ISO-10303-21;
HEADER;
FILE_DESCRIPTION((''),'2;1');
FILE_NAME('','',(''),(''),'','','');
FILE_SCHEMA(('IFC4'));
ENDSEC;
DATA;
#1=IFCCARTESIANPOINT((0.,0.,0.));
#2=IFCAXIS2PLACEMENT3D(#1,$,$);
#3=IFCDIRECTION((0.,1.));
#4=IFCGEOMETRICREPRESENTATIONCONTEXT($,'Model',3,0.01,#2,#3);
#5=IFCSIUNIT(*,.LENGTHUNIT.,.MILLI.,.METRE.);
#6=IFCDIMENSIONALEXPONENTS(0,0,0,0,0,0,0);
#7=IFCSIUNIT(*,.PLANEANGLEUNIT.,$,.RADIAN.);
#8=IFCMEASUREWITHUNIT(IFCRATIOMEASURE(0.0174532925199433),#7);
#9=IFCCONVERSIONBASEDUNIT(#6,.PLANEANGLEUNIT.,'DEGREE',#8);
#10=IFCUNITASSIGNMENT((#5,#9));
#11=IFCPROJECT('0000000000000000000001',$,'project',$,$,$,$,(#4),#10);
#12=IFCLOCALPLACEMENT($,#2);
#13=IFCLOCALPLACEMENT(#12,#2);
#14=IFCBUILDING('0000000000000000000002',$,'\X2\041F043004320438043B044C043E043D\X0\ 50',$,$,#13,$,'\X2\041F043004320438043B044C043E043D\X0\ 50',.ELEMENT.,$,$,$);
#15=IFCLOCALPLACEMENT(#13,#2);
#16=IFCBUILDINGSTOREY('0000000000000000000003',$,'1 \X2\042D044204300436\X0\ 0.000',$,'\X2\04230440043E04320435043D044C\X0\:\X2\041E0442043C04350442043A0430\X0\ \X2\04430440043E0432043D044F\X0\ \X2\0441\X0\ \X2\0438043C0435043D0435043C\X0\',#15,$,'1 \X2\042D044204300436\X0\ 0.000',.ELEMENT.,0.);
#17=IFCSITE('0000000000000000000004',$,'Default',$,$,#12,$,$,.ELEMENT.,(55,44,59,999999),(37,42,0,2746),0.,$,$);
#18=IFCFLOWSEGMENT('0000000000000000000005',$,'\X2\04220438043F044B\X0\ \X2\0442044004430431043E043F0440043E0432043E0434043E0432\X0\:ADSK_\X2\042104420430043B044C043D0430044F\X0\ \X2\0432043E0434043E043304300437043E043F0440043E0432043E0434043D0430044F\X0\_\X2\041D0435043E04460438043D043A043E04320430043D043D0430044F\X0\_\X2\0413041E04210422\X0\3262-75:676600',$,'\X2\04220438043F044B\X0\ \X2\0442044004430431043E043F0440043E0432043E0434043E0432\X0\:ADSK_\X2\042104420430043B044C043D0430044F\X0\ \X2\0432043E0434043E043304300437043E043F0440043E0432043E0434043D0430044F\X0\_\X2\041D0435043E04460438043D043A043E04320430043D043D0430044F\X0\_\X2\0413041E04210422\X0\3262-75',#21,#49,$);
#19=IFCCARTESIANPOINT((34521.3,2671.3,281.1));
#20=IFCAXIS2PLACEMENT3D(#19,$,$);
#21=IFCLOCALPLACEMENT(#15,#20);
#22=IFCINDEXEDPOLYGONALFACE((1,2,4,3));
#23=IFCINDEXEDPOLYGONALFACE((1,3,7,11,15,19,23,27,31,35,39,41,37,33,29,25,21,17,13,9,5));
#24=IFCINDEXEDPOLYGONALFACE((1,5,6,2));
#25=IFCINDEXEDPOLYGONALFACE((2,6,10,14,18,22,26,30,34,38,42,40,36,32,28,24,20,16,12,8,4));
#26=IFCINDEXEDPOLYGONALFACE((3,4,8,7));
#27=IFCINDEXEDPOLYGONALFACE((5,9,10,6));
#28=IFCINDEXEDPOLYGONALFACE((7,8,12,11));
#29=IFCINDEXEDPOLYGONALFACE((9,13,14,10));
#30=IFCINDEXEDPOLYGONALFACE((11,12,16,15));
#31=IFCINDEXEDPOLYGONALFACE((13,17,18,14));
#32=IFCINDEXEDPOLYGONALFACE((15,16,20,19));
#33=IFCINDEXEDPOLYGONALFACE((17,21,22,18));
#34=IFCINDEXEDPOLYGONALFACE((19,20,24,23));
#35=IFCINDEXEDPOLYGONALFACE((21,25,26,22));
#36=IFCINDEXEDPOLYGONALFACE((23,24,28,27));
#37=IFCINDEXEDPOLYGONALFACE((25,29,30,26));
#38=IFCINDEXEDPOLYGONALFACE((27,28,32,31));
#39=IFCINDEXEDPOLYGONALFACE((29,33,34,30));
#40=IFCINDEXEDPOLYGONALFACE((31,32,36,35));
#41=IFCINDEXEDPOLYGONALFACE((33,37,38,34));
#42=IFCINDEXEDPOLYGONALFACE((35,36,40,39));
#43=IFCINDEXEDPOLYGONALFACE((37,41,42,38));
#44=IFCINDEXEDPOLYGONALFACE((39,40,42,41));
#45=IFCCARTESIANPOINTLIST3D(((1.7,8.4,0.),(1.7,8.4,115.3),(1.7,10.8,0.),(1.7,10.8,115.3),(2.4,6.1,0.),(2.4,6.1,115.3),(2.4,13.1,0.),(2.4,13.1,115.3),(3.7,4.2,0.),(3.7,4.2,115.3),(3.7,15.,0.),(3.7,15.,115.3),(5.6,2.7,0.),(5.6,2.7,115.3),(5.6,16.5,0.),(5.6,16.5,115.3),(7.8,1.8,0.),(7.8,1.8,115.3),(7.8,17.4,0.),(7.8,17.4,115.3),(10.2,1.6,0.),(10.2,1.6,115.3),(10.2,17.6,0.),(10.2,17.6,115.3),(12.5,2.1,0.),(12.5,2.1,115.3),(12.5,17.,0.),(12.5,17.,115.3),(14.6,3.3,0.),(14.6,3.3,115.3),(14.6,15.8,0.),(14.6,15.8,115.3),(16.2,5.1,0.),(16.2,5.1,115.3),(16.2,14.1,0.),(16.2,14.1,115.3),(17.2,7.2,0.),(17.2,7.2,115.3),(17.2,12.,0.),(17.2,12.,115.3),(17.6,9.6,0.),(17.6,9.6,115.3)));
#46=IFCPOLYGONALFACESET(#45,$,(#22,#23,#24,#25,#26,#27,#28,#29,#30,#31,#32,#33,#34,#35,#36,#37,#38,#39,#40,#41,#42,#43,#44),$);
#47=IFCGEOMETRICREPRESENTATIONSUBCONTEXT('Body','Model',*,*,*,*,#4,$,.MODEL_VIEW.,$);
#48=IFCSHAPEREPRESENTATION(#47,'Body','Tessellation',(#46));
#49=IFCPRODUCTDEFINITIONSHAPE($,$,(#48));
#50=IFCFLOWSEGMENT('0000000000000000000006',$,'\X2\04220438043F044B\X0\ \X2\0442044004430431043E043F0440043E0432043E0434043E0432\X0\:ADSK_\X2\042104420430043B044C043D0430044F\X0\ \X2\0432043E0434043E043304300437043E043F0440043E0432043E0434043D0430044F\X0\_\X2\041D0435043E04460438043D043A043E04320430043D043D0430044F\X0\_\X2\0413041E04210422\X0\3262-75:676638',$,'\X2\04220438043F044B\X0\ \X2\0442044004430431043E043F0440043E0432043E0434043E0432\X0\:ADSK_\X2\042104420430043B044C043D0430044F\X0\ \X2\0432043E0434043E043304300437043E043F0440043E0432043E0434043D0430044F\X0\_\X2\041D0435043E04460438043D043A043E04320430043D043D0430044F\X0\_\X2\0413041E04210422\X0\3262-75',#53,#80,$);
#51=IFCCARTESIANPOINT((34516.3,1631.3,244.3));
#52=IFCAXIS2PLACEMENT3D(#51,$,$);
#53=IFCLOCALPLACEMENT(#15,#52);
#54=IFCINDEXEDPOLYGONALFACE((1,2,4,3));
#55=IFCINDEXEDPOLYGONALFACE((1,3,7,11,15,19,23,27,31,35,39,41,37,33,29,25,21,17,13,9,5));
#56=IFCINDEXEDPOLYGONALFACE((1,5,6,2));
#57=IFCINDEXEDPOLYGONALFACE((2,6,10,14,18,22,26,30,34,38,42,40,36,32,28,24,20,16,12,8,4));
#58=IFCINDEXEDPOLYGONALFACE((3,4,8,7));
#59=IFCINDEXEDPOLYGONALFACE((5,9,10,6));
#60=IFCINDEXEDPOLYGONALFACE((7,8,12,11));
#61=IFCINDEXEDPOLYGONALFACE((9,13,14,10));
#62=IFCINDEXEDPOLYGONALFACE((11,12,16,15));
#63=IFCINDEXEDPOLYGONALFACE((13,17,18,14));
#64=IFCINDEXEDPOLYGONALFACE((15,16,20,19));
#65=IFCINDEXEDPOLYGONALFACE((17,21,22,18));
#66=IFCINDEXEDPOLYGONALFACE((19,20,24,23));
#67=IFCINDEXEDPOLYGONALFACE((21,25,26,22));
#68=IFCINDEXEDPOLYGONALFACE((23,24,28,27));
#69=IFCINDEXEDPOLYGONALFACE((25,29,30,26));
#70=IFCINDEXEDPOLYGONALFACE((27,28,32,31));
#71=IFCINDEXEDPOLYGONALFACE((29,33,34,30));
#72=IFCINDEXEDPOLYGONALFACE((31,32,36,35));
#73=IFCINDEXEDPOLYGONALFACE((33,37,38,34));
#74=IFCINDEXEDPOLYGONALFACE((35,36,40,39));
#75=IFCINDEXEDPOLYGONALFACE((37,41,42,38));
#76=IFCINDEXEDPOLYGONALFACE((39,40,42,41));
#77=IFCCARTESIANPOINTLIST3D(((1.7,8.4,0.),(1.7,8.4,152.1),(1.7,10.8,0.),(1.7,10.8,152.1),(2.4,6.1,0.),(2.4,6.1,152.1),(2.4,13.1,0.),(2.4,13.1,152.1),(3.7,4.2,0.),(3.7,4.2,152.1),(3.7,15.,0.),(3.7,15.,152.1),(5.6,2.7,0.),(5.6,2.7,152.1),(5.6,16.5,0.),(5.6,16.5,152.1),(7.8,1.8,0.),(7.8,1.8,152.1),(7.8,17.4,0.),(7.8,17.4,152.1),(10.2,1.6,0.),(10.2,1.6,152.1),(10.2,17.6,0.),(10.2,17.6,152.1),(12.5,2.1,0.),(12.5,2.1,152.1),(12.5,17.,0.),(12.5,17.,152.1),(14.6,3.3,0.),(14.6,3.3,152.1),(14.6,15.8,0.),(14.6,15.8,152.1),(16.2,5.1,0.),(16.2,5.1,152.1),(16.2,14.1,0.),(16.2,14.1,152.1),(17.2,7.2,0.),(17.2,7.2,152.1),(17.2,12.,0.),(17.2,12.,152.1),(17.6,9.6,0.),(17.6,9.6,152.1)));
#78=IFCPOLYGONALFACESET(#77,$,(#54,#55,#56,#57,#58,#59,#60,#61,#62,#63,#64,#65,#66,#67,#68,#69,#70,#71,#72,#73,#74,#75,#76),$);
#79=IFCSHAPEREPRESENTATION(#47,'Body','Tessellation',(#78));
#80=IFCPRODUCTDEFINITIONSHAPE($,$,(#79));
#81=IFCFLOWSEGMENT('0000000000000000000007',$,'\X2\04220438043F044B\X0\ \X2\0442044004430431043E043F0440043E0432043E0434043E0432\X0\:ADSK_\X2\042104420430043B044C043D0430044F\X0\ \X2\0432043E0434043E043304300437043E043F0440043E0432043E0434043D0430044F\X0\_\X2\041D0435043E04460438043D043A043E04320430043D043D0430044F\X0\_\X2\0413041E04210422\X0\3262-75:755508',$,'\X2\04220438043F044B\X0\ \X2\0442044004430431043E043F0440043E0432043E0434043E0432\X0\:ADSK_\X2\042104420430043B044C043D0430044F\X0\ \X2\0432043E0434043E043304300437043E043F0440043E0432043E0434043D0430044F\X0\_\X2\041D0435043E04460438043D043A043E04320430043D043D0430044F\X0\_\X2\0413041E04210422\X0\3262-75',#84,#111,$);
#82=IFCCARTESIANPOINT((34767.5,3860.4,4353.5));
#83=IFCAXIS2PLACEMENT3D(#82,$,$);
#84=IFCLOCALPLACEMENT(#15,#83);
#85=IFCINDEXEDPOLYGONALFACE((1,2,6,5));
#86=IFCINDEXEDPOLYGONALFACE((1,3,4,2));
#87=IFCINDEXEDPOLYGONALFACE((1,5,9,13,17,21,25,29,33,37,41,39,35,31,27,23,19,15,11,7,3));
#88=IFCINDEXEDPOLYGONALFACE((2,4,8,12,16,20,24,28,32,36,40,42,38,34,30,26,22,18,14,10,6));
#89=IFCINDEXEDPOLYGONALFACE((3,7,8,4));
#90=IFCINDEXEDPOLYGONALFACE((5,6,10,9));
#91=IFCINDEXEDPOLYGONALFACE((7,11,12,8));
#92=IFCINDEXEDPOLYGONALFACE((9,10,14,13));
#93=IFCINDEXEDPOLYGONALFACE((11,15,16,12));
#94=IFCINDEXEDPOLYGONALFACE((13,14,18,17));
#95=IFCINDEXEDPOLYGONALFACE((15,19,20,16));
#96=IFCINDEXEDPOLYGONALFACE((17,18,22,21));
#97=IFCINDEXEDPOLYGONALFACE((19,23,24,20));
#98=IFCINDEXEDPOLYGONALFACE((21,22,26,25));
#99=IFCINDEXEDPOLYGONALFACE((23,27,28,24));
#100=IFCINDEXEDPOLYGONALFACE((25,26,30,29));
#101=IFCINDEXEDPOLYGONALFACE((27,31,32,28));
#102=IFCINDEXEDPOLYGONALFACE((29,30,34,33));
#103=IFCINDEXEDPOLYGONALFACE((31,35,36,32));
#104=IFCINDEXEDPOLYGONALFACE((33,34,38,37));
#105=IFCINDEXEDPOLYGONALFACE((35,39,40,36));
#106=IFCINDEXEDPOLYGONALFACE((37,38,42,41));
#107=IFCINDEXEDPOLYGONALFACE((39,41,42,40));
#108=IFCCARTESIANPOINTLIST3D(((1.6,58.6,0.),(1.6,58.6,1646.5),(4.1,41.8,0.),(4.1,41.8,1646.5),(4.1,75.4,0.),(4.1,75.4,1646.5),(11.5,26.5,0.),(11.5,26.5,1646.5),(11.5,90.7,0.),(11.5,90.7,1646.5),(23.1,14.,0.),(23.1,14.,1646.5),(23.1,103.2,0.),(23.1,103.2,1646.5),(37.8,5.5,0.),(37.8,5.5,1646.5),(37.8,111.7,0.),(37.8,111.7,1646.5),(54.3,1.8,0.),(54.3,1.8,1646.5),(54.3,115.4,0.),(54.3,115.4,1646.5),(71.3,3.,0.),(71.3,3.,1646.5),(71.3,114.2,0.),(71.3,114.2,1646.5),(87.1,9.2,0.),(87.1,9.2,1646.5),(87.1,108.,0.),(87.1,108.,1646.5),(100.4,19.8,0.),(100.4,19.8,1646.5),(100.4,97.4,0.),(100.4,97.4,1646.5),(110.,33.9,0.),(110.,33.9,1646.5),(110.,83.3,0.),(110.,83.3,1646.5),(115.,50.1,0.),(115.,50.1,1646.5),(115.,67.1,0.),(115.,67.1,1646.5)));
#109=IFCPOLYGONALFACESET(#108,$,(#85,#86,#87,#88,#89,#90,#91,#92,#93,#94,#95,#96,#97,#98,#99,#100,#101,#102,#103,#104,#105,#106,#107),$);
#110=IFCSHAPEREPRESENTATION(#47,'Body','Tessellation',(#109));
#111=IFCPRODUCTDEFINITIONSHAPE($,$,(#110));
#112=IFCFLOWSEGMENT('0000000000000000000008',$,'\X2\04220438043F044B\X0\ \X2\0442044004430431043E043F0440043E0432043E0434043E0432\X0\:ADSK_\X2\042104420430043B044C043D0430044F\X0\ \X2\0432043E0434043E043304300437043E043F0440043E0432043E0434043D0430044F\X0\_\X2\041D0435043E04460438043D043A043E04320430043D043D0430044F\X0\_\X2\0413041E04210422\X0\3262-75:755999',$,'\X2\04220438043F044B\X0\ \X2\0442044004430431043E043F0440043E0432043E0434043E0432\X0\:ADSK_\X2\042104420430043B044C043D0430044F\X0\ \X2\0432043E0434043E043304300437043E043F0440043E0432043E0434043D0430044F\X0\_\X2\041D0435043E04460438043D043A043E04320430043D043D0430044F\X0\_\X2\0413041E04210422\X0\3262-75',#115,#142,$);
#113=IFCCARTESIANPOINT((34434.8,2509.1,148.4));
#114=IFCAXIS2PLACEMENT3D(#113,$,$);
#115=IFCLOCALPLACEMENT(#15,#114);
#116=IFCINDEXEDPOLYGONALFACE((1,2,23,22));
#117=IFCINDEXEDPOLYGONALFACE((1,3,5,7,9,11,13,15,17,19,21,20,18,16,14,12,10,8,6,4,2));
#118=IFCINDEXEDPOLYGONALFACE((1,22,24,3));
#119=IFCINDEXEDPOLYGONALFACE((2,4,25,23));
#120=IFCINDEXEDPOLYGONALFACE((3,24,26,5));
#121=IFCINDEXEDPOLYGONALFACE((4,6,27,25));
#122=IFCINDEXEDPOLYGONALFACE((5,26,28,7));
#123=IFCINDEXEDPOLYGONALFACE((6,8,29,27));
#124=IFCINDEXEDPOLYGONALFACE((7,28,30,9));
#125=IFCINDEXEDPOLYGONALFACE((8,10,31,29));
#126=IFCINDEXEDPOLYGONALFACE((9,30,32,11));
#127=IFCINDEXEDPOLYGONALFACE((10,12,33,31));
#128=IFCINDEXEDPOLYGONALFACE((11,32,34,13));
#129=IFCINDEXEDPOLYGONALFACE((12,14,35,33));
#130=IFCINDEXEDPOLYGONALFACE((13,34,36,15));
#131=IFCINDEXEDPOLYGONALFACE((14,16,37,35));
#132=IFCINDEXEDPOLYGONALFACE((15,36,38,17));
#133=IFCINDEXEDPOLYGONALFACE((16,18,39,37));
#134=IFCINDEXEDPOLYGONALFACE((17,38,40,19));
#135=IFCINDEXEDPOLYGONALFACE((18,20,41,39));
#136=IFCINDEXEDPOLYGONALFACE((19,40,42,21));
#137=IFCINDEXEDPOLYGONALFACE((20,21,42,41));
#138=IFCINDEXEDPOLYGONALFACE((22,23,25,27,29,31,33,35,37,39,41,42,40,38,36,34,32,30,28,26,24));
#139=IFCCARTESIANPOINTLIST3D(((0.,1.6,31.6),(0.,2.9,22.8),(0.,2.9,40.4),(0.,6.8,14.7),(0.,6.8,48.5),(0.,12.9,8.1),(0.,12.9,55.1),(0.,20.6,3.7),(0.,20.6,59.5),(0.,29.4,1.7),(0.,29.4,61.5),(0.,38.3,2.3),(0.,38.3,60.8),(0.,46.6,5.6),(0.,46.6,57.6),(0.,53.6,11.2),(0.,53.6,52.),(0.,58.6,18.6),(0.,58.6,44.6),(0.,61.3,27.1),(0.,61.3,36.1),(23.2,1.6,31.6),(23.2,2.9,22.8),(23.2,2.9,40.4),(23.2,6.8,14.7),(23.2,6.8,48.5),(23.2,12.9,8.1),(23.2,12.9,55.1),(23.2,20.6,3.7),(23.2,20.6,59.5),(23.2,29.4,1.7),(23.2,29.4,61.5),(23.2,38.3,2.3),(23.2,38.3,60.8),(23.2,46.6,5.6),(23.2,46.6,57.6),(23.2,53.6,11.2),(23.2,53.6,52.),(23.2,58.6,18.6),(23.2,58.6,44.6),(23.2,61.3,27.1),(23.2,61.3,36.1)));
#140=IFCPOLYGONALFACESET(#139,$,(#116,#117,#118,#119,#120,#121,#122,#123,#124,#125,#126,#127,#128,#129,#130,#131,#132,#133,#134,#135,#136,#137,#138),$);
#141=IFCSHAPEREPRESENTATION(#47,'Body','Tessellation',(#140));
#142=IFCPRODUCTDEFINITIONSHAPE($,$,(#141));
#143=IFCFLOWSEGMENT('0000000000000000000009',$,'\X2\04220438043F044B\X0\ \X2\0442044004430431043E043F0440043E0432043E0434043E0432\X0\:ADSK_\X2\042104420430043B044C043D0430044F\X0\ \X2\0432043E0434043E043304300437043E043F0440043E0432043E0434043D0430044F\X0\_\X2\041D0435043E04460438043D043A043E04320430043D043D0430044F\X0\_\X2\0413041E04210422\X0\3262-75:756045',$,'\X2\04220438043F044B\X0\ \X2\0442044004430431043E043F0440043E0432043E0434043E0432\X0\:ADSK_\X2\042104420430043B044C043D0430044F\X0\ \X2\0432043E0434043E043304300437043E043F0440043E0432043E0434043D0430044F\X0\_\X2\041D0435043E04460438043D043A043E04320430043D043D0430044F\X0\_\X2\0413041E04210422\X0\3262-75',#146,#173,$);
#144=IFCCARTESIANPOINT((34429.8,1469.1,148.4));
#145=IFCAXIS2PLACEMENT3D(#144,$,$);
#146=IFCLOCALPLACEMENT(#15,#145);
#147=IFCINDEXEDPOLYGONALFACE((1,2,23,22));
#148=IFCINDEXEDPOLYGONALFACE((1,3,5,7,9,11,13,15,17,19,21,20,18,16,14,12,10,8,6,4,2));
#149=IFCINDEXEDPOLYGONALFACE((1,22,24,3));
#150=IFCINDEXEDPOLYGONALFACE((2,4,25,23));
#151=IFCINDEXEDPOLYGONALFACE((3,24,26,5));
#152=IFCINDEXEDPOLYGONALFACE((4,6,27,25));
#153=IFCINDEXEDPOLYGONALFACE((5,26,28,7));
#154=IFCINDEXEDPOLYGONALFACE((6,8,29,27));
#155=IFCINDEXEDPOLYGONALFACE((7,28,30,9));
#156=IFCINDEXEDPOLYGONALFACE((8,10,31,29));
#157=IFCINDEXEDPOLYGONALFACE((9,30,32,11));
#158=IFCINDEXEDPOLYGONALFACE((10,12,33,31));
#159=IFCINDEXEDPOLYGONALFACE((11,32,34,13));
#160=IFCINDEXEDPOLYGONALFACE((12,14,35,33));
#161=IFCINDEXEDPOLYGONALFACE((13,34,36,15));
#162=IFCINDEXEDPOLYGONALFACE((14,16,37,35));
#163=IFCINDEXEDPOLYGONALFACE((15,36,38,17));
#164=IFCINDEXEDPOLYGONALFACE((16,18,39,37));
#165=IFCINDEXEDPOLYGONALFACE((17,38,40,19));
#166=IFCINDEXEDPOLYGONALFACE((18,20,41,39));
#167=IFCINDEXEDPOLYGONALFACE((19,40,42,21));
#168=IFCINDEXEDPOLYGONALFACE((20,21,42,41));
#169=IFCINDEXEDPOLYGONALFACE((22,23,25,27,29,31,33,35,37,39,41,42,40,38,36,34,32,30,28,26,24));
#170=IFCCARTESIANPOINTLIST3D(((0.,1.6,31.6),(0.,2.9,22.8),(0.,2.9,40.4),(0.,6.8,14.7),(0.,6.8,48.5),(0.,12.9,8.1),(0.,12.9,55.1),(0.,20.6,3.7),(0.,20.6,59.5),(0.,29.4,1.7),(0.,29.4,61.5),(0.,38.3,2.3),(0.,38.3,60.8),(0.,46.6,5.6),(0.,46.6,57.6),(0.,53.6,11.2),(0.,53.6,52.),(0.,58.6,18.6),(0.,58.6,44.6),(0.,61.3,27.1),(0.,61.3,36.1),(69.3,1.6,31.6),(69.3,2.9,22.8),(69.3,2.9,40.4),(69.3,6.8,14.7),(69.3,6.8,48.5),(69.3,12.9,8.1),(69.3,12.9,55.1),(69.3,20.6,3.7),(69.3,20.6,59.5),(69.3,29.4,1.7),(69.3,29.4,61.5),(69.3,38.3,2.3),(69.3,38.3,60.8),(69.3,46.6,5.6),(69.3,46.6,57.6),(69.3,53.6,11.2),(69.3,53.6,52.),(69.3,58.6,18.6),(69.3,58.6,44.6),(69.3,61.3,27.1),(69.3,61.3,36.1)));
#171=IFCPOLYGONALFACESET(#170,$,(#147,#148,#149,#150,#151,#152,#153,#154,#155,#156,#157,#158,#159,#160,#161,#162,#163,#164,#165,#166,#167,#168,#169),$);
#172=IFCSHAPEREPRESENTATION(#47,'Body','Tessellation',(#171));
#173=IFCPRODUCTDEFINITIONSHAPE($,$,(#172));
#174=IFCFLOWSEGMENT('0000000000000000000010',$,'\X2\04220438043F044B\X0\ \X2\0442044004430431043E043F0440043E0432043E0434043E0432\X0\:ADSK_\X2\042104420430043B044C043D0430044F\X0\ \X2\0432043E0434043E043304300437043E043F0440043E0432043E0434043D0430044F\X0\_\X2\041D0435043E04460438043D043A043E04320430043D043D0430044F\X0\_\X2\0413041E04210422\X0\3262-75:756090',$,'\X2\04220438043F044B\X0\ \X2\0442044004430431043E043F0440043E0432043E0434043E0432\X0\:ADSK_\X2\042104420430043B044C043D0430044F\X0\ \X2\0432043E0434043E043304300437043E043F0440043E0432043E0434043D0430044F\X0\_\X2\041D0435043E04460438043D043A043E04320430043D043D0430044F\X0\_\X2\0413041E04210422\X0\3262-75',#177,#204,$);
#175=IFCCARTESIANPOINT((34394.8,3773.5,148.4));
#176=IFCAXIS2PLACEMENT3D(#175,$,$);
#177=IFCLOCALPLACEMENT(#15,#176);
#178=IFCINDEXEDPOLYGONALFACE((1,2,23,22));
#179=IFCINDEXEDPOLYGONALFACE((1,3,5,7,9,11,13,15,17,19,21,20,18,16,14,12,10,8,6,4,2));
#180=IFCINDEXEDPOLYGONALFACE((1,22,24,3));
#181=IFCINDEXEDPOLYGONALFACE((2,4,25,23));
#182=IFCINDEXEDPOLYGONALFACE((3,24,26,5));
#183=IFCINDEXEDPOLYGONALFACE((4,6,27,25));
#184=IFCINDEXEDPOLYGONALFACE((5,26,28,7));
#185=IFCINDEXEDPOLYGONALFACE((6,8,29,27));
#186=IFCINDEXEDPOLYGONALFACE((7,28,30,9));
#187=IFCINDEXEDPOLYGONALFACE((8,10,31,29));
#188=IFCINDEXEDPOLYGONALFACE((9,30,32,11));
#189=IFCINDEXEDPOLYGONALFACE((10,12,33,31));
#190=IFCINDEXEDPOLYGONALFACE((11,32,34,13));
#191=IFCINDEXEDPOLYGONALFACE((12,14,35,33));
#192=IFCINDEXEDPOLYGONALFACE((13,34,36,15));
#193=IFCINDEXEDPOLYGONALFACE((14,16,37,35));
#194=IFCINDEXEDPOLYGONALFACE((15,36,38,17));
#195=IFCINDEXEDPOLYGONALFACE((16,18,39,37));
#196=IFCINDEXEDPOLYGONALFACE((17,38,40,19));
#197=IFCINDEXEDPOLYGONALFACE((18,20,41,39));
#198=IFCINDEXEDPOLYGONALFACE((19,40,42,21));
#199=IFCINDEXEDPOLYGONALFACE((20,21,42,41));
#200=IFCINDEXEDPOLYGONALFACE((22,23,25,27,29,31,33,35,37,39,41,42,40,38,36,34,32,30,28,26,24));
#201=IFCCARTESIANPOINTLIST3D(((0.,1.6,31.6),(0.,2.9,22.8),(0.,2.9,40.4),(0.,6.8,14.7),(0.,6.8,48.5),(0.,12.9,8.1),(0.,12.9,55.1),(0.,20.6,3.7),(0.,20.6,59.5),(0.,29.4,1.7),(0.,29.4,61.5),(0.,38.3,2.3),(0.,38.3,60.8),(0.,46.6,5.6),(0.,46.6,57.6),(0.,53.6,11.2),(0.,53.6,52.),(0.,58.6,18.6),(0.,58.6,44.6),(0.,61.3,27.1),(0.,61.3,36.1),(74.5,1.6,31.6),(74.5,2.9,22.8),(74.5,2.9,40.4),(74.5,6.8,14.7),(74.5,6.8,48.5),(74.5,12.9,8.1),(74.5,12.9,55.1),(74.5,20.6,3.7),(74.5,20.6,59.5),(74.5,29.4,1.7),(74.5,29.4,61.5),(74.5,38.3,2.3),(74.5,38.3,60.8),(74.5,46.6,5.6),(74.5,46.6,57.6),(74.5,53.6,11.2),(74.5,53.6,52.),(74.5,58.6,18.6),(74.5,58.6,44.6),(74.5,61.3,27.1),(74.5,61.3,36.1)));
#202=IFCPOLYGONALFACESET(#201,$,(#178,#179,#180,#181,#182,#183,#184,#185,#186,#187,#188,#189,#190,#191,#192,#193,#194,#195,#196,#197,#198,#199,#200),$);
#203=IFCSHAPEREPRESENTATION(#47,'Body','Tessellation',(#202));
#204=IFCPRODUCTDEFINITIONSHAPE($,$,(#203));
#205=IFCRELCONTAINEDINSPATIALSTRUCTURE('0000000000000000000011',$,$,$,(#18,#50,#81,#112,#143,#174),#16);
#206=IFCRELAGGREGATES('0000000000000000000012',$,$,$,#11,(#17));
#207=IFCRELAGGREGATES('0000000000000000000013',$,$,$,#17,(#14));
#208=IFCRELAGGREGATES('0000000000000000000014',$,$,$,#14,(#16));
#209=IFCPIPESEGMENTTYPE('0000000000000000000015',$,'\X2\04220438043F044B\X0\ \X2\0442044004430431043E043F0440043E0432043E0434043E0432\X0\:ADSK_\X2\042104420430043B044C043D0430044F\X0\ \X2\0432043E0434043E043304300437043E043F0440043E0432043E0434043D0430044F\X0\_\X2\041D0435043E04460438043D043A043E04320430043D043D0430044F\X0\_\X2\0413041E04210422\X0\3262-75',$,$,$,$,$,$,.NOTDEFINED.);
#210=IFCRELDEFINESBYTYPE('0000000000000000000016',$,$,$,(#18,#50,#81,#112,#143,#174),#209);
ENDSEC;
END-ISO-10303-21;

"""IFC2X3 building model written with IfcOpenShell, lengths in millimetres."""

from ifc_helpers import new_model, entity, si_unit, converted_unit, direction, frame, frame_2d, origin, origin_2d_with_axis, place, context, subcontext, project, spatial, circle, extrude, type_object, element, save


model = new_model("IFC2X3")

# Units and contexts
model_context = context("Model", 3, precision=0.01, world=origin(), true_north=direction((0.0, 1.0)))
body_context = subcontext(model_context, "Body", "Model", "MODEL_VIEW")
ifc_project = project(units=[si_unit("LENGTHUNIT", "METRE", prefix="MILLI"), converted_unit("PLANEANGLEUNIT", "DEGREE", entity("IfcRatioMeasure", 0.0174532925199433), si_unit("PLANEANGLEUNIT", "RADIAN"), dimensions=[0, 0, 0, 0, 0, 0, 0])], contexts=[model_context])

# Site, building, storey
site_placement = place(None, origin())
site = spatial("IfcSite", under=ifc_project, at=site_placement, Name="Default", CompositionType="ELEMENT", RefLatitude=(55, 44, 59, 999999), RefLongitude=(37, 42, 0, 2746), RefElevation=0.0)
building_placement = place(site_placement, origin())
building = spatial("IfcBuilding", under=site, at=building_placement, Name="Павильон 50", LongName="Павильон 50", CompositionType="ELEMENT")
storey_placement = place(building_placement, origin())
storey = spatial("IfcBuildingStorey", under=building, at=storey_placement, Name="1 Этаж 0.000", ObjectType="Уровень:Отметка уровня с именем", LongName="1 Этаж 0.000", CompositionType="ELEMENT", Elevation=0.0)

# Flow segments
pipe_segment_type = type_object("IfcPipeSegmentType", Name="Типы трубопроводов:ADSK_Стальная водогазопроводная_Неоцинкованная_ГОСТ3262-75", PredefinedType="NOTDEFINED")
flow_segment_1_placement = place(storey_placement, frame((34521.3, 2671.3, 281.1)))
element("IfcFlowSegment", 1, at=flow_segment_1_placement, inside=storey, type_object=pipe_segment_type, Name="Типы трубопроводов:ADSK_Стальная водогазопроводная_Неоцинкованная_ГОСТ3262-75:676600", ObjectType="Типы трубопроводов:ADSK_Стальная водогазопроводная_Неоцинкованная_ГОСТ3262-75", context=body_context, shape_type="SweptSolid", body=[
    extrude(circle(Radius=8.0, at=origin_2d_with_axis()), frame((9.6, 9.6, 0.0)), (0.0, 0.0, 1.0), 115.3),
])
flow_segment_2_placement = place(storey_placement, frame((34516.3, 1631.3, 244.3)))
element("IfcFlowSegment", 2, at=flow_segment_2_placement, inside=storey, type_object=pipe_segment_type, Name="Типы трубопроводов:ADSK_Стальная водогазопроводная_Неоцинкованная_ГОСТ3262-75:676638", ObjectType="Типы трубопроводов:ADSK_Стальная водогазопроводная_Неоцинкованная_ГОСТ3262-75", context=body_context, shape_type="SweptSolid", body=[
    extrude(circle(Radius=8.0, at=frame_2d((0.0, 0.0), x_axis=(1.0, 0.0))), frame((9.6, 9.6, 0.0)), (0.0, 0.0, 1.0), 152.1),
])
flow_segment_3_placement = place(storey_placement, frame((34767.5, 3860.4, 4353.5)))
element("IfcFlowSegment", 3, at=flow_segment_3_placement, inside=storey, type_object=pipe_segment_type, Name="Типы трубопроводов:ADSK_Стальная водогазопроводная_Неоцинкованная_ГОСТ3262-75:755508", ObjectType="Типы трубопроводов:ADSK_Стальная водогазопроводная_Неоцинкованная_ГОСТ3262-75", context=body_context, shape_type="SweptSolid", body=[
    extrude(circle(Radius=57.0, at=origin_2d_with_axis()), frame((58.6, 58.6, 0.0), z_axis=(0.0, 0.0, 1.0), x_axis=(-1.0, 0.0, 0.0)), (0.0, 0.0, 1.0), 1646.5),
])
flow_segment_4_placement = place(storey_placement, frame((34434.8, 2509.1, 148.4)))
element("IfcFlowSegment", 4, at=flow_segment_4_placement, inside=storey, type_object=pipe_segment_type, Name="Типы трубопроводов:ADSK_Стальная водогазопроводная_Неоцинкованная_ГОСТ3262-75:755999", ObjectType="Типы трубопроводов:ADSK_Стальная водогазопроводная_Неоцинкованная_ГОСТ3262-75", context=body_context, shape_type="SweptSolid", body=[
    extrude(circle(Radius=30.0, at=frame_2d((0.0, 0.0), x_axis=(1.0, 0.0))), frame((0.0, 31.6, 31.6), z_axis=(1.0, 0.0, 0.0), x_axis=(0.0, -1.0, 0.0)), (0.0, 0.0, 1.0), 23.2),
])
flow_segment_5_placement = place(storey_placement, frame((34429.8, 1469.1, 148.4)))
element("IfcFlowSegment", 5, at=flow_segment_5_placement, inside=storey, type_object=pipe_segment_type, Name="Типы трубопроводов:ADSK_Стальная водогазопроводная_Неоцинкованная_ГОСТ3262-75:756045", ObjectType="Типы трубопроводов:ADSK_Стальная водогазопроводная_Неоцинкованная_ГОСТ3262-75", context=body_context, shape_type="SweptSolid", body=[
    extrude(circle(Radius=30.0, at=frame_2d((0.0, 0.0), x_axis=(1.0, 0.0))), frame((0.0, 31.6, 31.6), z_axis=(1.0, 0.0, 0.0), x_axis=(0.0, -1.0, 0.0)), (0.0, 0.0, 1.0), 69.3),
])
flow_segment_6_placement = place(storey_placement, frame((34394.8, 3773.5, 148.4)))
element("IfcFlowSegment", 6, at=flow_segment_6_placement, inside=storey, type_object=pipe_segment_type, Name="Типы трубопроводов:ADSK_Стальная водогазопроводная_Неоцинкованная_ГОСТ3262-75:756090", ObjectType="Типы трубопроводов:ADSK_Стальная водогазопроводная_Неоцинкованная_ГОСТ3262-75", context=body_context, shape_type="SweptSolid", body=[
    extrude(circle(Radius=30.0, at=frame_2d((0.0, 0.0), x_axis=(1.0, 0.0))), frame((0.0, 31.6, 31.6), z_axis=(1.0, 0.0, 0.0), x_axis=(0.0, -1.0, 0.0)), (0.0, 0.0, 1.0), 74.5),
])

save(model, "model.ifc")
